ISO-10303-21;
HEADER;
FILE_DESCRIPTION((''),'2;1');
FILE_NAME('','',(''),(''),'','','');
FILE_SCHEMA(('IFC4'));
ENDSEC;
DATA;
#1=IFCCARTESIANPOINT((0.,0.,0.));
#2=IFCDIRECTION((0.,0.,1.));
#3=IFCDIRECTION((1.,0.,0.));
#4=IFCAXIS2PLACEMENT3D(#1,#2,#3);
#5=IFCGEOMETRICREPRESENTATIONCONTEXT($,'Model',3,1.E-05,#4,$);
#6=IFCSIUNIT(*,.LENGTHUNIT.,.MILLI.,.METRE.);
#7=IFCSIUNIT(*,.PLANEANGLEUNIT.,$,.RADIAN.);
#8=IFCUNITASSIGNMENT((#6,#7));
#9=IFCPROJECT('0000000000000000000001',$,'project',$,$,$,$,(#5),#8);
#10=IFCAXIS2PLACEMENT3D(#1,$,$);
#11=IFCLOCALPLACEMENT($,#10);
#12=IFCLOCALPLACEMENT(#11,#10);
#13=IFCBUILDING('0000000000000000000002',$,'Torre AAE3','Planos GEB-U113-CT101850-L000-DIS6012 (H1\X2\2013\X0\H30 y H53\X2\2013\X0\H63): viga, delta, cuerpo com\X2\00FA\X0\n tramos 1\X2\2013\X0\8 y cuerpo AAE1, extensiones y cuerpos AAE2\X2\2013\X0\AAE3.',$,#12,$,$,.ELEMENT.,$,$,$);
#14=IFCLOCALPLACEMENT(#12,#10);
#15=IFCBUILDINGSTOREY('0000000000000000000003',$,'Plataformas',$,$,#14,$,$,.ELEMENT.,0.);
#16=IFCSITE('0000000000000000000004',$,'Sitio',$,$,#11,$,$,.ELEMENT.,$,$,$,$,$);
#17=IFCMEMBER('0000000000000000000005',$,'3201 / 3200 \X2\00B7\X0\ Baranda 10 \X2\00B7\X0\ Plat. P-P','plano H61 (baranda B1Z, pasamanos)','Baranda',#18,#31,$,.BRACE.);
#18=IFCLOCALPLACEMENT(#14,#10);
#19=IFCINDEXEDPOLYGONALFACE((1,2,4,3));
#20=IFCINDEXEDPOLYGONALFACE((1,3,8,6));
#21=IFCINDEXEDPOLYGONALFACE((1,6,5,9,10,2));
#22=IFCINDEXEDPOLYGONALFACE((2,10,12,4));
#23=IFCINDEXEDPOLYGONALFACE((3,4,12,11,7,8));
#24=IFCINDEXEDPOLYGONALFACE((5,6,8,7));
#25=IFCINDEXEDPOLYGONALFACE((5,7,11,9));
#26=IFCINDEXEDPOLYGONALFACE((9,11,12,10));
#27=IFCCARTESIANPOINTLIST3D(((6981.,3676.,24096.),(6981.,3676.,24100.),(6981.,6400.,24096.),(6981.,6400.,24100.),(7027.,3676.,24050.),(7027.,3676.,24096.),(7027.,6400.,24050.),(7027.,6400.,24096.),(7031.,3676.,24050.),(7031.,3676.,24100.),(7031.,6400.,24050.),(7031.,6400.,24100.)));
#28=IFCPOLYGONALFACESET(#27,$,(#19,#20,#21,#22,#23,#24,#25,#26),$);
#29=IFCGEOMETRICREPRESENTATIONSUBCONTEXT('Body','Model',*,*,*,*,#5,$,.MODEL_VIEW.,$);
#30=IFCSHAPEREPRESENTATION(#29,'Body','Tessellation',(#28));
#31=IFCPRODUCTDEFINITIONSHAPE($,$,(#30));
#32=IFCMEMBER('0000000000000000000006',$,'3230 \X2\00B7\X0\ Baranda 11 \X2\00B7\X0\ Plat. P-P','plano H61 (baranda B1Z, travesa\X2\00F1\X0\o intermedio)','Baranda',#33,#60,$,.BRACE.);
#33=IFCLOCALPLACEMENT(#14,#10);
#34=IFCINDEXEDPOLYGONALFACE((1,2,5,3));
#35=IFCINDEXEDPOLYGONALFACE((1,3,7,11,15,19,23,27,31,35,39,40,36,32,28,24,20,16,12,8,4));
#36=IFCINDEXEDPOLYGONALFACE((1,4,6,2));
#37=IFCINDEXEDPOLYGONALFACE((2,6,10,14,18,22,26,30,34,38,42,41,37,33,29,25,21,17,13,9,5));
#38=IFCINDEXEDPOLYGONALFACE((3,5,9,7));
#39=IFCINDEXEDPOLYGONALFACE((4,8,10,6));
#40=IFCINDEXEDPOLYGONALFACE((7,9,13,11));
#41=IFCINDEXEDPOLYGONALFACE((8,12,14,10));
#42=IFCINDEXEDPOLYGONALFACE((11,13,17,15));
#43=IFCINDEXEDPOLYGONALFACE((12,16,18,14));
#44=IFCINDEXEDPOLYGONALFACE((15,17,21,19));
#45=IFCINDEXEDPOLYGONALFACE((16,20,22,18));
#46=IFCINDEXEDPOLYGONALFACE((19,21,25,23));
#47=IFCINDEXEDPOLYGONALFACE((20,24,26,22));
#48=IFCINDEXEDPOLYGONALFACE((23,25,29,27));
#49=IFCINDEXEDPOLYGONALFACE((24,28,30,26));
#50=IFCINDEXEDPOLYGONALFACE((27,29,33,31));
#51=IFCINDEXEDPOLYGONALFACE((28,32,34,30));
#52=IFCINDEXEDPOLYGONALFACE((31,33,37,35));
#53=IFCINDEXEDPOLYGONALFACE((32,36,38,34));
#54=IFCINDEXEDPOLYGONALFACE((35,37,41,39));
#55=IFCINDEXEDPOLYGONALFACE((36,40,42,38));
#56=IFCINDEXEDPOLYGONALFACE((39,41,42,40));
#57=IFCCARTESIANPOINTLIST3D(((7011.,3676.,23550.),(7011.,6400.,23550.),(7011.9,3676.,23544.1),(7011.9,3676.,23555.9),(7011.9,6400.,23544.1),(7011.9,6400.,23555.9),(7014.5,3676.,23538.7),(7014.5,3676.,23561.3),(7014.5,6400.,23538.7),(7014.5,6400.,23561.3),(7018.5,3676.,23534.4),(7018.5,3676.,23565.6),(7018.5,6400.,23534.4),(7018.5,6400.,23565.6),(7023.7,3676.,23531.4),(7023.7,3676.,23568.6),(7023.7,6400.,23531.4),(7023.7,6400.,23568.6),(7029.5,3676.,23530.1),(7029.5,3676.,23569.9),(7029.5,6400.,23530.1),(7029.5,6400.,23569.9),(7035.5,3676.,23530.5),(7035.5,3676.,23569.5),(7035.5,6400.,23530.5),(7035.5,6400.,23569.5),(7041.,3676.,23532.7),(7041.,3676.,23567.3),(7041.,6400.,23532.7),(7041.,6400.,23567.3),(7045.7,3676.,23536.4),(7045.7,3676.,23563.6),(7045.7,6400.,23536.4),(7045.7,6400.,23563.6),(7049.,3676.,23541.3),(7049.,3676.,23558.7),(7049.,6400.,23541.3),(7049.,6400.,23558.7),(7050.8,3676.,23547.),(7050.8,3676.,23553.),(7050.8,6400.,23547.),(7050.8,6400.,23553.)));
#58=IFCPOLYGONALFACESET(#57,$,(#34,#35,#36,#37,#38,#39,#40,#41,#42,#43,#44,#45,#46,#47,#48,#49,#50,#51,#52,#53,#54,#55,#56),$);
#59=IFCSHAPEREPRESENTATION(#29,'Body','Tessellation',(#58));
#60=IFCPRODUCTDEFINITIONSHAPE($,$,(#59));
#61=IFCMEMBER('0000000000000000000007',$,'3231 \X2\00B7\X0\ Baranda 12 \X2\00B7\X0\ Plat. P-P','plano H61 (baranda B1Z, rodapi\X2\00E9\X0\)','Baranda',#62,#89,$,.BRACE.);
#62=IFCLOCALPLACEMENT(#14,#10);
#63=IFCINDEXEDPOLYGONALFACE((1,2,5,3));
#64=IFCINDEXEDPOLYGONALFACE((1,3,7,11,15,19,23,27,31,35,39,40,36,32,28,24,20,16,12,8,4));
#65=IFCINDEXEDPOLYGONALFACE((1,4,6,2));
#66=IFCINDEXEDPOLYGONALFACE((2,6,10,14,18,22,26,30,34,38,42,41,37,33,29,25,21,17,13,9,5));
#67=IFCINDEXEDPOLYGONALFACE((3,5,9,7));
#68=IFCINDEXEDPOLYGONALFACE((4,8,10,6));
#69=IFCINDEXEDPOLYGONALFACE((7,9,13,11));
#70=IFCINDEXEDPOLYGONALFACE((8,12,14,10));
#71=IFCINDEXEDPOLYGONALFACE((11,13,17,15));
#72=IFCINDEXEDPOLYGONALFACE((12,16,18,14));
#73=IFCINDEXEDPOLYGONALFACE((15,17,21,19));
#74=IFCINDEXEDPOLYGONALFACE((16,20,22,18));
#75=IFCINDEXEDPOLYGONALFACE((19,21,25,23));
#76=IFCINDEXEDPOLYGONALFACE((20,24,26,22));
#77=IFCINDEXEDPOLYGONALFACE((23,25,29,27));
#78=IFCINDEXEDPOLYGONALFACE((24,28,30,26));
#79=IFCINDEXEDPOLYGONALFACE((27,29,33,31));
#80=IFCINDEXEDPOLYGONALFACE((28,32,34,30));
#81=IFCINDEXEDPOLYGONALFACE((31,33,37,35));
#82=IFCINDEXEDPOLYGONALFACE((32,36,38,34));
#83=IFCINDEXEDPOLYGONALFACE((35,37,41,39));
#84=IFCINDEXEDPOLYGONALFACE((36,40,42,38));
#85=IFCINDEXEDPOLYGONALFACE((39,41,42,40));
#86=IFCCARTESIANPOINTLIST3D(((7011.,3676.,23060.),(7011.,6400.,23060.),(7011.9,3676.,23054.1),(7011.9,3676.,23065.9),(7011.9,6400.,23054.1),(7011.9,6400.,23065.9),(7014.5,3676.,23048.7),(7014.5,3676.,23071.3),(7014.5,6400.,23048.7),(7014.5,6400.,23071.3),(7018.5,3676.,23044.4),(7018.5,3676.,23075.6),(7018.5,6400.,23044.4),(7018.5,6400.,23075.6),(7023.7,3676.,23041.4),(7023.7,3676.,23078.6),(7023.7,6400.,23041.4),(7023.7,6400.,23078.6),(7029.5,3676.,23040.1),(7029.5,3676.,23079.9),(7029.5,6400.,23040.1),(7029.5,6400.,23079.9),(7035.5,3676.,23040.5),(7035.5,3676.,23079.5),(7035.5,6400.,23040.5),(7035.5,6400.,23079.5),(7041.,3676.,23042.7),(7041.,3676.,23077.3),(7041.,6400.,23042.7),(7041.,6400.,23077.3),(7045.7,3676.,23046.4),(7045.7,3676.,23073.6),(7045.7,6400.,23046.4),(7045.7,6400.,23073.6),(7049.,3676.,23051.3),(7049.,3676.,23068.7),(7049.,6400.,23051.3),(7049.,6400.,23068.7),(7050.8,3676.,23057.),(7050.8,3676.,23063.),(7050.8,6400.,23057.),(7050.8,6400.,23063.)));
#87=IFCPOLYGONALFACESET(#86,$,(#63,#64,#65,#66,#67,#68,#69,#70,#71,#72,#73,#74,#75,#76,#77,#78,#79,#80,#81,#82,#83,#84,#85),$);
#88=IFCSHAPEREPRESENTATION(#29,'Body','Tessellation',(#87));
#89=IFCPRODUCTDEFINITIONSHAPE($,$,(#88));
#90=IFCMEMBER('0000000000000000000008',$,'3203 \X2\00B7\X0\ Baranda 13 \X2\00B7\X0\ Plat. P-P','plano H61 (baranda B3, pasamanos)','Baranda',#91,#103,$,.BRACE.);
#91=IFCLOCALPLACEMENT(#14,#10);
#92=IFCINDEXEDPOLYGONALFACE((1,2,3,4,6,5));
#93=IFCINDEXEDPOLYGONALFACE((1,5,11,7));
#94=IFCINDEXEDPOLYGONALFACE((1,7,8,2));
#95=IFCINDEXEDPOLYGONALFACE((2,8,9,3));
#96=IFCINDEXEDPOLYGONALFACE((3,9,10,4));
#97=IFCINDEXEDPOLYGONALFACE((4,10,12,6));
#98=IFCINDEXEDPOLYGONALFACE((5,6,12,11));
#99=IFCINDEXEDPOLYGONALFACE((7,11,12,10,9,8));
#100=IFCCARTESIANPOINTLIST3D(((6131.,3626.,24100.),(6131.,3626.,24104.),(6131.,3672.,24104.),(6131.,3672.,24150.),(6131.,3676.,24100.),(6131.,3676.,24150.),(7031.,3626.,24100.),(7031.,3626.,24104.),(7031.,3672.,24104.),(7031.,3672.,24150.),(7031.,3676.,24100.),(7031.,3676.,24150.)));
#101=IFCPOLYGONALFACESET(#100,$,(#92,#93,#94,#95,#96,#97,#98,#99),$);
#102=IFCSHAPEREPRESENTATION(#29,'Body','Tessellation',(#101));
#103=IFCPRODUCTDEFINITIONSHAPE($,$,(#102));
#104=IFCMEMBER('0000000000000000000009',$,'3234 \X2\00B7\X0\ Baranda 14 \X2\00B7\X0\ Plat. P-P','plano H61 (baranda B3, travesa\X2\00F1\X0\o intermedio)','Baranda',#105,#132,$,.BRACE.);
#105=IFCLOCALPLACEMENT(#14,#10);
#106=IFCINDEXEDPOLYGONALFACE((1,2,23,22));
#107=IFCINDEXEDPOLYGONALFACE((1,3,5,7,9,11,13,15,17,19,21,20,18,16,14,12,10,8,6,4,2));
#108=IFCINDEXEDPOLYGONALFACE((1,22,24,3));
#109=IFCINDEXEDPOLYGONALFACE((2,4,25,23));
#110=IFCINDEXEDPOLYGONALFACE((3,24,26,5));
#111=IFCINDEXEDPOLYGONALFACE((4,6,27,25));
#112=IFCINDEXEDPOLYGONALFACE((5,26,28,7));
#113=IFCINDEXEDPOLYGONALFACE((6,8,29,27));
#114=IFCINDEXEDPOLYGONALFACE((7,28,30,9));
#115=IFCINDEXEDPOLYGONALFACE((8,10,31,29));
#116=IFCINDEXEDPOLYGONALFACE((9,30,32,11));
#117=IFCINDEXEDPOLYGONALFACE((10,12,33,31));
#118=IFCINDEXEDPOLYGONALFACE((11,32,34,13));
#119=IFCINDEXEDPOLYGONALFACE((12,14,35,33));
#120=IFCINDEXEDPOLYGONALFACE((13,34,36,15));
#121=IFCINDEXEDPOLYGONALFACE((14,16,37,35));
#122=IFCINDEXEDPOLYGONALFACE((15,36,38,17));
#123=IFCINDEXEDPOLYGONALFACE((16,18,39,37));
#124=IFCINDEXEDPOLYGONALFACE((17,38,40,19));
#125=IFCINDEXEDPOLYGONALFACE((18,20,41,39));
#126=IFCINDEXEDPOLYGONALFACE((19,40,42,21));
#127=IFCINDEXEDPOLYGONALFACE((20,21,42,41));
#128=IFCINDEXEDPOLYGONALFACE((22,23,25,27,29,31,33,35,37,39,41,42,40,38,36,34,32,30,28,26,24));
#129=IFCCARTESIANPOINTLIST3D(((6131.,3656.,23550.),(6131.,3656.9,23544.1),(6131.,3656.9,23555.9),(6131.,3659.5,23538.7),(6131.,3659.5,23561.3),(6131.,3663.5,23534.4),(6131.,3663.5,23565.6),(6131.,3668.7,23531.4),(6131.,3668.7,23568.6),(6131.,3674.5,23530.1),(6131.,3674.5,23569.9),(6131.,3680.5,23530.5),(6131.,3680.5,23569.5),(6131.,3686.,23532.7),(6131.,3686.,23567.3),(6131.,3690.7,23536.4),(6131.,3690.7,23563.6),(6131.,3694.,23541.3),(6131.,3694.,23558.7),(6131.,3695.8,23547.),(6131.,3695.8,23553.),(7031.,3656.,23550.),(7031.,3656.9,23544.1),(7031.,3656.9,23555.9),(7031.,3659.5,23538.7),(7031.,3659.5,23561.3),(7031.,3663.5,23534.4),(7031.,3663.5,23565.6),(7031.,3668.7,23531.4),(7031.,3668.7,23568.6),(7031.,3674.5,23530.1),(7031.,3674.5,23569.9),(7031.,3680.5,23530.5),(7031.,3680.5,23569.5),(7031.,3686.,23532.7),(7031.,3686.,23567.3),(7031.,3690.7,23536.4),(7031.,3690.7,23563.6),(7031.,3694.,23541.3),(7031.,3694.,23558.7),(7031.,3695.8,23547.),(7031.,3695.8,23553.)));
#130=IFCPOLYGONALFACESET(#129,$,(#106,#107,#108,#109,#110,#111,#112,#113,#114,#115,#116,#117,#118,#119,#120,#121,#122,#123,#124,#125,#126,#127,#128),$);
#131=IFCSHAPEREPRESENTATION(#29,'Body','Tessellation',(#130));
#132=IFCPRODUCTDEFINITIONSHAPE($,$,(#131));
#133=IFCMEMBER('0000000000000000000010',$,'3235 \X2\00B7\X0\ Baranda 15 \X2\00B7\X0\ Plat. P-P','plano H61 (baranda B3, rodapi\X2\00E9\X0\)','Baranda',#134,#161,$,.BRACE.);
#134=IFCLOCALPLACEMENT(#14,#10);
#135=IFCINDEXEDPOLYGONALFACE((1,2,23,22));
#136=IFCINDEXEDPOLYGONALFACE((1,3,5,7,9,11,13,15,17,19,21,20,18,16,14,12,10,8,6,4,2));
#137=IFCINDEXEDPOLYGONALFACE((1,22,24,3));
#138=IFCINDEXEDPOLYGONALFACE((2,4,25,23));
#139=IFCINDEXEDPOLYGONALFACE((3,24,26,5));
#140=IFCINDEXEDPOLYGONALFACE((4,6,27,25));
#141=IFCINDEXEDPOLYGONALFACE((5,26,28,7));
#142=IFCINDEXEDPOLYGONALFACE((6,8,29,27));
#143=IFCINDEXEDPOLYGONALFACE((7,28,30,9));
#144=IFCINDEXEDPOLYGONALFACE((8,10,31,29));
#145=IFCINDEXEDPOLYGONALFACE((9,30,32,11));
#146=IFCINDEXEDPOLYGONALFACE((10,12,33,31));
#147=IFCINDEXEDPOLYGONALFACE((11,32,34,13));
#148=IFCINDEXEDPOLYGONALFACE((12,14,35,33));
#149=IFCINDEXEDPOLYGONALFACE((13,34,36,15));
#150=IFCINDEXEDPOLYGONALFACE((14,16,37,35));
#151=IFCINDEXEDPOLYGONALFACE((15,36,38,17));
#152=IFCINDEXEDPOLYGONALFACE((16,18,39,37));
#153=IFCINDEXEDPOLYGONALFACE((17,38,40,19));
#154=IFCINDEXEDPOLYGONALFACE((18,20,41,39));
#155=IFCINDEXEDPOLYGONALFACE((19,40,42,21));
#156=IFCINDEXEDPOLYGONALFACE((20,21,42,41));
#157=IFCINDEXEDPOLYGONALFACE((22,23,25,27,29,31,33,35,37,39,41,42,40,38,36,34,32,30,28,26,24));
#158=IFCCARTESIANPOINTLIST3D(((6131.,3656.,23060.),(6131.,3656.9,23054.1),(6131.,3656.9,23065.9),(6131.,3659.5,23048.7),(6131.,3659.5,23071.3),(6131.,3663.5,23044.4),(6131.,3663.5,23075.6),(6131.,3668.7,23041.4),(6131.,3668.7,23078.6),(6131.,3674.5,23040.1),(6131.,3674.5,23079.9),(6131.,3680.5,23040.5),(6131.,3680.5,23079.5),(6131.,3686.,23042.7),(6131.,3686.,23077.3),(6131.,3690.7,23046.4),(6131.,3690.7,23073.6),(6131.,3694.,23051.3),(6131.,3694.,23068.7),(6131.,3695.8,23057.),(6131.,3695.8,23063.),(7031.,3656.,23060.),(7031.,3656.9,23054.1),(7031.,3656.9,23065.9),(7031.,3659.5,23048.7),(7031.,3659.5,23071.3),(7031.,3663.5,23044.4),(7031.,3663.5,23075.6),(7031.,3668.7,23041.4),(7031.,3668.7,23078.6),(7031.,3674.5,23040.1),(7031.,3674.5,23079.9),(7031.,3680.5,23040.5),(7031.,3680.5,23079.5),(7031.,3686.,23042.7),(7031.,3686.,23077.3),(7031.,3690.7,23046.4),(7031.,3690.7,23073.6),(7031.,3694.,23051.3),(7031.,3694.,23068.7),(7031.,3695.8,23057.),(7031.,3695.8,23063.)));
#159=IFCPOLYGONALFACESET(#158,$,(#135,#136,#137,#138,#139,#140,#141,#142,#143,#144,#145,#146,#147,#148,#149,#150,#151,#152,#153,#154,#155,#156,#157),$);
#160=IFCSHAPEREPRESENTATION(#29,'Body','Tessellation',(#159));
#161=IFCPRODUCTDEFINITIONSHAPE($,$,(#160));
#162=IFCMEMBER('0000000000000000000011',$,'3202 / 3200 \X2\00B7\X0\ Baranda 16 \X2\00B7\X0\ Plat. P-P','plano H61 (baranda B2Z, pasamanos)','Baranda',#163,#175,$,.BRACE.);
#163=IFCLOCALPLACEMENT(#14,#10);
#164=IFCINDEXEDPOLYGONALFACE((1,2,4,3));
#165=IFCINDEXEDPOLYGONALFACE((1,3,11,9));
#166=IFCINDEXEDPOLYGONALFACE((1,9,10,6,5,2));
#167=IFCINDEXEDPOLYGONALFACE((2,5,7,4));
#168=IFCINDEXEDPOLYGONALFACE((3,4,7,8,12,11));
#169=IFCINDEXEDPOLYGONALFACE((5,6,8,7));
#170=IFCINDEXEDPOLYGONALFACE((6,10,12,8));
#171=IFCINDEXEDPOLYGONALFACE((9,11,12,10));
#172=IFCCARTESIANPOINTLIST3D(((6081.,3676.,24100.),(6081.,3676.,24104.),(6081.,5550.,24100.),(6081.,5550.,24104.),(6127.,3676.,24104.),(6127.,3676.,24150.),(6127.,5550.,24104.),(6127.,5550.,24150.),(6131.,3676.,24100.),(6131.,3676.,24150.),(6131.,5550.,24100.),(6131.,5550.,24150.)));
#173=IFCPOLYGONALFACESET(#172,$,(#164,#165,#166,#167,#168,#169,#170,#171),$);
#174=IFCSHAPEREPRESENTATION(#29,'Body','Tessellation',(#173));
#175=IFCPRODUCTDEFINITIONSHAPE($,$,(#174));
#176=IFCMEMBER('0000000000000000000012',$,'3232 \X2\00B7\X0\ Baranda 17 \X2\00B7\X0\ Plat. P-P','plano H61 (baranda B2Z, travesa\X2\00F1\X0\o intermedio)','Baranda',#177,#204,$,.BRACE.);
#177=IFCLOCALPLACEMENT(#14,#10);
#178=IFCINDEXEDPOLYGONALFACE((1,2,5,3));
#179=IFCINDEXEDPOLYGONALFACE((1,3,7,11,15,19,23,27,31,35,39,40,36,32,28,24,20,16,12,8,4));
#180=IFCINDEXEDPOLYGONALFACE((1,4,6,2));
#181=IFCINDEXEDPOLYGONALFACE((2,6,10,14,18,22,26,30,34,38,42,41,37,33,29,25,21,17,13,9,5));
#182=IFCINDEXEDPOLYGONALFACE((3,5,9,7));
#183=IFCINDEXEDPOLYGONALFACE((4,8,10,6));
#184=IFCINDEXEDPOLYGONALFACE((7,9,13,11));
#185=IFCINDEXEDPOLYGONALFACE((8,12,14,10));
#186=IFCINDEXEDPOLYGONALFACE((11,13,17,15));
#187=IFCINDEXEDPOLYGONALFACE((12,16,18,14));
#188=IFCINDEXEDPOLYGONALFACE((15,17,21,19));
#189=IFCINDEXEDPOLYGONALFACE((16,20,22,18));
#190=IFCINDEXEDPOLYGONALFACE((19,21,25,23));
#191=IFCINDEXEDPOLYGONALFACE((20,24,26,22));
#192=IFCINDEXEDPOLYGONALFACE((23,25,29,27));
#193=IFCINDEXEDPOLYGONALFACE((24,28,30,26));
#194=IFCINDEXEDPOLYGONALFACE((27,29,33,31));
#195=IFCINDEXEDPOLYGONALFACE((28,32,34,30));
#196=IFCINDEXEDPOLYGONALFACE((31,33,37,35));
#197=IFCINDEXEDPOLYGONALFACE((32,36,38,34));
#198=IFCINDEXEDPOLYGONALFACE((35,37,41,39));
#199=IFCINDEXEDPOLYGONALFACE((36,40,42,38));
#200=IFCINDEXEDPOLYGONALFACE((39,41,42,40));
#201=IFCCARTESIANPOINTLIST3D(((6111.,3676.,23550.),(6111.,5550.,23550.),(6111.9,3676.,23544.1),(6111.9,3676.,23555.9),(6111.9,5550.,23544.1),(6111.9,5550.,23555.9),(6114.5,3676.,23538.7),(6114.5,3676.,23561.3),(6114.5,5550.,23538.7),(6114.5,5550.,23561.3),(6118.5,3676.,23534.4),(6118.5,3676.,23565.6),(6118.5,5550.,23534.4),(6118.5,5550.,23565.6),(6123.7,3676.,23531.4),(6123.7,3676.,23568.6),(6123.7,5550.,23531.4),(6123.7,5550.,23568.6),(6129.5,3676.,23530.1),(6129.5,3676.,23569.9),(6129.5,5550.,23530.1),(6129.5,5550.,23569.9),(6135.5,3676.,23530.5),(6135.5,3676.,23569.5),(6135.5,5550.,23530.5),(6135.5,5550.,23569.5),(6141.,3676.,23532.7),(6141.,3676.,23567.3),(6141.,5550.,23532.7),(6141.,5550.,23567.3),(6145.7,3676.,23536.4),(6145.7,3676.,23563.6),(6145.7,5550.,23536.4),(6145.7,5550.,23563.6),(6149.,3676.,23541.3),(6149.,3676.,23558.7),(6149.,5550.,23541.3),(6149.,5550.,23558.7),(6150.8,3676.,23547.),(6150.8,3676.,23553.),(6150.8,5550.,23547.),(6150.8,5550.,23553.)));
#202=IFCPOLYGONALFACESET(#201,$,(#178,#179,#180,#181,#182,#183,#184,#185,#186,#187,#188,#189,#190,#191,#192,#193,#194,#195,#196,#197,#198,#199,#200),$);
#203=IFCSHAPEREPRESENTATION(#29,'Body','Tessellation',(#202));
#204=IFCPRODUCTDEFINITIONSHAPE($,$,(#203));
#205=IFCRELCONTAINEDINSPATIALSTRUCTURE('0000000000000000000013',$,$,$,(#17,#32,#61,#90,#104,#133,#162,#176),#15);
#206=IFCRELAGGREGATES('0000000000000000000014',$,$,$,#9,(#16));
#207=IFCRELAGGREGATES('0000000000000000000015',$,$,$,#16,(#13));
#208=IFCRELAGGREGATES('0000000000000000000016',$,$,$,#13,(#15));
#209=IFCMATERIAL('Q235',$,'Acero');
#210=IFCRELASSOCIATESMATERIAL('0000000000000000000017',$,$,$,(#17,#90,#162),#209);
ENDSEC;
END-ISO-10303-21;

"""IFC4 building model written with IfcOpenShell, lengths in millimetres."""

from ifc_helpers import new_model, si_unit, frame, frame_2d, origin, origin_with_axes, place, context, subcontext, project, spatial, circle, l_section, extrude, material, element, save


model = new_model("IFC4")

# Units and contexts
model_context = context("Model", 3, precision=1e-05, world=origin_with_axes())
body_context = subcontext(model_context, "Body", "Model", "MODEL_VIEW")
ifc_project = project(units=[si_unit("LENGTHUNIT", "METRE", prefix="MILLI"), si_unit("PLANEANGLEUNIT", "RADIAN")], contexts=[model_context])

# Site, building, storey
site_placement = place(None, origin())
site = spatial("IfcSite", under=ifc_project, at=site_placement, Name="Sitio", CompositionType="ELEMENT")
building_placement = place(site_placement, origin())
building = spatial("IfcBuilding", under=site, at=building_placement, Name="Torre AAE3", Description="Planos GEB-U113-CT101850-L000-DIS6012 (H1–H30 y H53–H63): viga, delta, cuerpo común tramos 1–8 y cuerpo AAE1, extensiones y cuerpos AAE2–AAE3.", CompositionType="ELEMENT")
storey_placement = place(building_placement, origin())
storey = spatial("IfcBuildingStorey", under=building, at=storey_placement, Name="Plataformas", CompositionType="ELEMENT", Elevation=0.0)

# Members
ifc_material = material(Name="Q235", Category="Acero")
member_1_placement = place(storey_placement, frame((7031.0, 6400.0, 24100.0), z_axis=(0.0, -1.0, 0.0), x_axis=(-1.0, 0.0, 0.0)))
element("IfcMember", 1, at=member_1_placement, inside=storey, material=ifc_material, Name="3201 / 3200 · Baranda 10 · Plat. P-P", Description="plano H61 (baranda B1Z, pasamanos)", ObjectType="Baranda", PredefinedType="BRACE", context=body_context, shape_type="SweptSolid", body=[
    extrude(l_section(Depth=50.0, Width=50.0, Thickness=4.0, at=frame_2d((25.0, 25.0))), None, (0.0, 0.0, 1.0), 2724.0),
])
for number, where, z_axis, x_axis, name, description in (
    (2, (7031.0, 6400.0, 23550.0), (0.0, -1.0, 0.0), (-1.0, 0.0, 0.0), "3230 · Baranda 11 · Plat. P-P", "plano H61 (baranda B1Z, travesaño intermedio)"),
    (3, (7031.0, 6400.0, 23060.0), (0.0, -1.0, 0.0), (-1.0, 0.0, 0.0), "3231 · Baranda 12 · Plat. P-P", "plano H61 (baranda B1Z, rodapié)"),
):
    element("IfcMember", number, at=place(storey_placement, frame(where, z_axis=z_axis, x_axis=x_axis)), inside=storey, Name=name, Description=description, ObjectType="Baranda", PredefinedType="BRACE", context=body_context, shape_type="SweptSolid", body=[
        extrude(circle(Radius=20.0), None, (0.0, 0.0, 1.0), 2724.0),
    ])
member_2_placement = place(storey_placement, frame((7031.0, 3676.0, 24100.0), z_axis=(-1.0, 0.0, 0.0), x_axis=(0.0, -1.0, 0.0)))
element("IfcMember", 4, at=member_2_placement, inside=storey, material=ifc_material, Name="3203 · Baranda 13 · Plat. P-P", Description="plano H61 (baranda B3, pasamanos)", ObjectType="Baranda", PredefinedType="BRACE", context=body_context, shape_type="SweptSolid", body=[
    extrude(l_section(Depth=50.0, Width=50.0, Thickness=4.0, at=frame_2d((25.0, 25.0))), None, (0.0, 0.0, 1.0), 900.0),
])
for number, where, z_axis, x_axis, name, description in (
    (5, (7031.0, 3676.0, 23550.0), (-1.0, 0.0, 0.0), (0.0, -1.0, 0.0), "3234 · Baranda 14 · Plat. P-P", "plano H61 (baranda B3, travesaño intermedio)"),
    (6, (7031.0, 3676.0, 23060.0), (-1.0, 0.0, 0.0), (0.0, -1.0, 0.0), "3235 · Baranda 15 · Plat. P-P", "plano H61 (baranda B3, rodapié)"),
):
    element("IfcMember", number, at=place(storey_placement, frame(where, z_axis=z_axis, x_axis=x_axis)), inside=storey, Name=name, Description=description, ObjectType="Baranda", PredefinedType="BRACE", context=body_context, shape_type="SweptSolid", body=[
        extrude(circle(Radius=20.0), None, (0.0, 0.0, 1.0), 900.0),
    ])
member_3_placement = place(storey_placement, frame((6131.0, 3676.0, 24100.0), z_axis=(0.0, 1.0, 0.0), x_axis=(-1.0, 0.0, 0.0)))
element("IfcMember", 7, at=member_3_placement, inside=storey, material=ifc_material, Name="3202 / 3200 · Baranda 16 · Plat. P-P", Description="plano H61 (baranda B2Z, pasamanos)", ObjectType="Baranda", PredefinedType="BRACE", context=body_context, shape_type="SweptSolid", body=[
    extrude(l_section(Depth=50.0, Width=50.0, Thickness=4.0, at=frame_2d((25.0, 25.0))), None, (0.0, 0.0, 1.0), 1874.0),
])
for number, where, z_axis, x_axis, name in (
    (8, (6131.0, 3676.0, 23550.0), (0.0, 1.0, 0.0), (-1.0, 0.0, 0.0), "3232 · Baranda 17 · Plat. P-P"),
):
    element("IfcMember", number, at=place(storey_placement, frame(where, z_axis=z_axis, x_axis=x_axis)), inside=storey, Name=name, Description="plano H61 (baranda B2Z, travesaño intermedio)", ObjectType="Baranda", PredefinedType="BRACE", context=body_context, shape_type="SweptSolid", body=[
        extrude(circle(Radius=20.0), None, (0.0, 0.0, 1.0), 1874.0),
    ])

save(model, "model.ifc")
